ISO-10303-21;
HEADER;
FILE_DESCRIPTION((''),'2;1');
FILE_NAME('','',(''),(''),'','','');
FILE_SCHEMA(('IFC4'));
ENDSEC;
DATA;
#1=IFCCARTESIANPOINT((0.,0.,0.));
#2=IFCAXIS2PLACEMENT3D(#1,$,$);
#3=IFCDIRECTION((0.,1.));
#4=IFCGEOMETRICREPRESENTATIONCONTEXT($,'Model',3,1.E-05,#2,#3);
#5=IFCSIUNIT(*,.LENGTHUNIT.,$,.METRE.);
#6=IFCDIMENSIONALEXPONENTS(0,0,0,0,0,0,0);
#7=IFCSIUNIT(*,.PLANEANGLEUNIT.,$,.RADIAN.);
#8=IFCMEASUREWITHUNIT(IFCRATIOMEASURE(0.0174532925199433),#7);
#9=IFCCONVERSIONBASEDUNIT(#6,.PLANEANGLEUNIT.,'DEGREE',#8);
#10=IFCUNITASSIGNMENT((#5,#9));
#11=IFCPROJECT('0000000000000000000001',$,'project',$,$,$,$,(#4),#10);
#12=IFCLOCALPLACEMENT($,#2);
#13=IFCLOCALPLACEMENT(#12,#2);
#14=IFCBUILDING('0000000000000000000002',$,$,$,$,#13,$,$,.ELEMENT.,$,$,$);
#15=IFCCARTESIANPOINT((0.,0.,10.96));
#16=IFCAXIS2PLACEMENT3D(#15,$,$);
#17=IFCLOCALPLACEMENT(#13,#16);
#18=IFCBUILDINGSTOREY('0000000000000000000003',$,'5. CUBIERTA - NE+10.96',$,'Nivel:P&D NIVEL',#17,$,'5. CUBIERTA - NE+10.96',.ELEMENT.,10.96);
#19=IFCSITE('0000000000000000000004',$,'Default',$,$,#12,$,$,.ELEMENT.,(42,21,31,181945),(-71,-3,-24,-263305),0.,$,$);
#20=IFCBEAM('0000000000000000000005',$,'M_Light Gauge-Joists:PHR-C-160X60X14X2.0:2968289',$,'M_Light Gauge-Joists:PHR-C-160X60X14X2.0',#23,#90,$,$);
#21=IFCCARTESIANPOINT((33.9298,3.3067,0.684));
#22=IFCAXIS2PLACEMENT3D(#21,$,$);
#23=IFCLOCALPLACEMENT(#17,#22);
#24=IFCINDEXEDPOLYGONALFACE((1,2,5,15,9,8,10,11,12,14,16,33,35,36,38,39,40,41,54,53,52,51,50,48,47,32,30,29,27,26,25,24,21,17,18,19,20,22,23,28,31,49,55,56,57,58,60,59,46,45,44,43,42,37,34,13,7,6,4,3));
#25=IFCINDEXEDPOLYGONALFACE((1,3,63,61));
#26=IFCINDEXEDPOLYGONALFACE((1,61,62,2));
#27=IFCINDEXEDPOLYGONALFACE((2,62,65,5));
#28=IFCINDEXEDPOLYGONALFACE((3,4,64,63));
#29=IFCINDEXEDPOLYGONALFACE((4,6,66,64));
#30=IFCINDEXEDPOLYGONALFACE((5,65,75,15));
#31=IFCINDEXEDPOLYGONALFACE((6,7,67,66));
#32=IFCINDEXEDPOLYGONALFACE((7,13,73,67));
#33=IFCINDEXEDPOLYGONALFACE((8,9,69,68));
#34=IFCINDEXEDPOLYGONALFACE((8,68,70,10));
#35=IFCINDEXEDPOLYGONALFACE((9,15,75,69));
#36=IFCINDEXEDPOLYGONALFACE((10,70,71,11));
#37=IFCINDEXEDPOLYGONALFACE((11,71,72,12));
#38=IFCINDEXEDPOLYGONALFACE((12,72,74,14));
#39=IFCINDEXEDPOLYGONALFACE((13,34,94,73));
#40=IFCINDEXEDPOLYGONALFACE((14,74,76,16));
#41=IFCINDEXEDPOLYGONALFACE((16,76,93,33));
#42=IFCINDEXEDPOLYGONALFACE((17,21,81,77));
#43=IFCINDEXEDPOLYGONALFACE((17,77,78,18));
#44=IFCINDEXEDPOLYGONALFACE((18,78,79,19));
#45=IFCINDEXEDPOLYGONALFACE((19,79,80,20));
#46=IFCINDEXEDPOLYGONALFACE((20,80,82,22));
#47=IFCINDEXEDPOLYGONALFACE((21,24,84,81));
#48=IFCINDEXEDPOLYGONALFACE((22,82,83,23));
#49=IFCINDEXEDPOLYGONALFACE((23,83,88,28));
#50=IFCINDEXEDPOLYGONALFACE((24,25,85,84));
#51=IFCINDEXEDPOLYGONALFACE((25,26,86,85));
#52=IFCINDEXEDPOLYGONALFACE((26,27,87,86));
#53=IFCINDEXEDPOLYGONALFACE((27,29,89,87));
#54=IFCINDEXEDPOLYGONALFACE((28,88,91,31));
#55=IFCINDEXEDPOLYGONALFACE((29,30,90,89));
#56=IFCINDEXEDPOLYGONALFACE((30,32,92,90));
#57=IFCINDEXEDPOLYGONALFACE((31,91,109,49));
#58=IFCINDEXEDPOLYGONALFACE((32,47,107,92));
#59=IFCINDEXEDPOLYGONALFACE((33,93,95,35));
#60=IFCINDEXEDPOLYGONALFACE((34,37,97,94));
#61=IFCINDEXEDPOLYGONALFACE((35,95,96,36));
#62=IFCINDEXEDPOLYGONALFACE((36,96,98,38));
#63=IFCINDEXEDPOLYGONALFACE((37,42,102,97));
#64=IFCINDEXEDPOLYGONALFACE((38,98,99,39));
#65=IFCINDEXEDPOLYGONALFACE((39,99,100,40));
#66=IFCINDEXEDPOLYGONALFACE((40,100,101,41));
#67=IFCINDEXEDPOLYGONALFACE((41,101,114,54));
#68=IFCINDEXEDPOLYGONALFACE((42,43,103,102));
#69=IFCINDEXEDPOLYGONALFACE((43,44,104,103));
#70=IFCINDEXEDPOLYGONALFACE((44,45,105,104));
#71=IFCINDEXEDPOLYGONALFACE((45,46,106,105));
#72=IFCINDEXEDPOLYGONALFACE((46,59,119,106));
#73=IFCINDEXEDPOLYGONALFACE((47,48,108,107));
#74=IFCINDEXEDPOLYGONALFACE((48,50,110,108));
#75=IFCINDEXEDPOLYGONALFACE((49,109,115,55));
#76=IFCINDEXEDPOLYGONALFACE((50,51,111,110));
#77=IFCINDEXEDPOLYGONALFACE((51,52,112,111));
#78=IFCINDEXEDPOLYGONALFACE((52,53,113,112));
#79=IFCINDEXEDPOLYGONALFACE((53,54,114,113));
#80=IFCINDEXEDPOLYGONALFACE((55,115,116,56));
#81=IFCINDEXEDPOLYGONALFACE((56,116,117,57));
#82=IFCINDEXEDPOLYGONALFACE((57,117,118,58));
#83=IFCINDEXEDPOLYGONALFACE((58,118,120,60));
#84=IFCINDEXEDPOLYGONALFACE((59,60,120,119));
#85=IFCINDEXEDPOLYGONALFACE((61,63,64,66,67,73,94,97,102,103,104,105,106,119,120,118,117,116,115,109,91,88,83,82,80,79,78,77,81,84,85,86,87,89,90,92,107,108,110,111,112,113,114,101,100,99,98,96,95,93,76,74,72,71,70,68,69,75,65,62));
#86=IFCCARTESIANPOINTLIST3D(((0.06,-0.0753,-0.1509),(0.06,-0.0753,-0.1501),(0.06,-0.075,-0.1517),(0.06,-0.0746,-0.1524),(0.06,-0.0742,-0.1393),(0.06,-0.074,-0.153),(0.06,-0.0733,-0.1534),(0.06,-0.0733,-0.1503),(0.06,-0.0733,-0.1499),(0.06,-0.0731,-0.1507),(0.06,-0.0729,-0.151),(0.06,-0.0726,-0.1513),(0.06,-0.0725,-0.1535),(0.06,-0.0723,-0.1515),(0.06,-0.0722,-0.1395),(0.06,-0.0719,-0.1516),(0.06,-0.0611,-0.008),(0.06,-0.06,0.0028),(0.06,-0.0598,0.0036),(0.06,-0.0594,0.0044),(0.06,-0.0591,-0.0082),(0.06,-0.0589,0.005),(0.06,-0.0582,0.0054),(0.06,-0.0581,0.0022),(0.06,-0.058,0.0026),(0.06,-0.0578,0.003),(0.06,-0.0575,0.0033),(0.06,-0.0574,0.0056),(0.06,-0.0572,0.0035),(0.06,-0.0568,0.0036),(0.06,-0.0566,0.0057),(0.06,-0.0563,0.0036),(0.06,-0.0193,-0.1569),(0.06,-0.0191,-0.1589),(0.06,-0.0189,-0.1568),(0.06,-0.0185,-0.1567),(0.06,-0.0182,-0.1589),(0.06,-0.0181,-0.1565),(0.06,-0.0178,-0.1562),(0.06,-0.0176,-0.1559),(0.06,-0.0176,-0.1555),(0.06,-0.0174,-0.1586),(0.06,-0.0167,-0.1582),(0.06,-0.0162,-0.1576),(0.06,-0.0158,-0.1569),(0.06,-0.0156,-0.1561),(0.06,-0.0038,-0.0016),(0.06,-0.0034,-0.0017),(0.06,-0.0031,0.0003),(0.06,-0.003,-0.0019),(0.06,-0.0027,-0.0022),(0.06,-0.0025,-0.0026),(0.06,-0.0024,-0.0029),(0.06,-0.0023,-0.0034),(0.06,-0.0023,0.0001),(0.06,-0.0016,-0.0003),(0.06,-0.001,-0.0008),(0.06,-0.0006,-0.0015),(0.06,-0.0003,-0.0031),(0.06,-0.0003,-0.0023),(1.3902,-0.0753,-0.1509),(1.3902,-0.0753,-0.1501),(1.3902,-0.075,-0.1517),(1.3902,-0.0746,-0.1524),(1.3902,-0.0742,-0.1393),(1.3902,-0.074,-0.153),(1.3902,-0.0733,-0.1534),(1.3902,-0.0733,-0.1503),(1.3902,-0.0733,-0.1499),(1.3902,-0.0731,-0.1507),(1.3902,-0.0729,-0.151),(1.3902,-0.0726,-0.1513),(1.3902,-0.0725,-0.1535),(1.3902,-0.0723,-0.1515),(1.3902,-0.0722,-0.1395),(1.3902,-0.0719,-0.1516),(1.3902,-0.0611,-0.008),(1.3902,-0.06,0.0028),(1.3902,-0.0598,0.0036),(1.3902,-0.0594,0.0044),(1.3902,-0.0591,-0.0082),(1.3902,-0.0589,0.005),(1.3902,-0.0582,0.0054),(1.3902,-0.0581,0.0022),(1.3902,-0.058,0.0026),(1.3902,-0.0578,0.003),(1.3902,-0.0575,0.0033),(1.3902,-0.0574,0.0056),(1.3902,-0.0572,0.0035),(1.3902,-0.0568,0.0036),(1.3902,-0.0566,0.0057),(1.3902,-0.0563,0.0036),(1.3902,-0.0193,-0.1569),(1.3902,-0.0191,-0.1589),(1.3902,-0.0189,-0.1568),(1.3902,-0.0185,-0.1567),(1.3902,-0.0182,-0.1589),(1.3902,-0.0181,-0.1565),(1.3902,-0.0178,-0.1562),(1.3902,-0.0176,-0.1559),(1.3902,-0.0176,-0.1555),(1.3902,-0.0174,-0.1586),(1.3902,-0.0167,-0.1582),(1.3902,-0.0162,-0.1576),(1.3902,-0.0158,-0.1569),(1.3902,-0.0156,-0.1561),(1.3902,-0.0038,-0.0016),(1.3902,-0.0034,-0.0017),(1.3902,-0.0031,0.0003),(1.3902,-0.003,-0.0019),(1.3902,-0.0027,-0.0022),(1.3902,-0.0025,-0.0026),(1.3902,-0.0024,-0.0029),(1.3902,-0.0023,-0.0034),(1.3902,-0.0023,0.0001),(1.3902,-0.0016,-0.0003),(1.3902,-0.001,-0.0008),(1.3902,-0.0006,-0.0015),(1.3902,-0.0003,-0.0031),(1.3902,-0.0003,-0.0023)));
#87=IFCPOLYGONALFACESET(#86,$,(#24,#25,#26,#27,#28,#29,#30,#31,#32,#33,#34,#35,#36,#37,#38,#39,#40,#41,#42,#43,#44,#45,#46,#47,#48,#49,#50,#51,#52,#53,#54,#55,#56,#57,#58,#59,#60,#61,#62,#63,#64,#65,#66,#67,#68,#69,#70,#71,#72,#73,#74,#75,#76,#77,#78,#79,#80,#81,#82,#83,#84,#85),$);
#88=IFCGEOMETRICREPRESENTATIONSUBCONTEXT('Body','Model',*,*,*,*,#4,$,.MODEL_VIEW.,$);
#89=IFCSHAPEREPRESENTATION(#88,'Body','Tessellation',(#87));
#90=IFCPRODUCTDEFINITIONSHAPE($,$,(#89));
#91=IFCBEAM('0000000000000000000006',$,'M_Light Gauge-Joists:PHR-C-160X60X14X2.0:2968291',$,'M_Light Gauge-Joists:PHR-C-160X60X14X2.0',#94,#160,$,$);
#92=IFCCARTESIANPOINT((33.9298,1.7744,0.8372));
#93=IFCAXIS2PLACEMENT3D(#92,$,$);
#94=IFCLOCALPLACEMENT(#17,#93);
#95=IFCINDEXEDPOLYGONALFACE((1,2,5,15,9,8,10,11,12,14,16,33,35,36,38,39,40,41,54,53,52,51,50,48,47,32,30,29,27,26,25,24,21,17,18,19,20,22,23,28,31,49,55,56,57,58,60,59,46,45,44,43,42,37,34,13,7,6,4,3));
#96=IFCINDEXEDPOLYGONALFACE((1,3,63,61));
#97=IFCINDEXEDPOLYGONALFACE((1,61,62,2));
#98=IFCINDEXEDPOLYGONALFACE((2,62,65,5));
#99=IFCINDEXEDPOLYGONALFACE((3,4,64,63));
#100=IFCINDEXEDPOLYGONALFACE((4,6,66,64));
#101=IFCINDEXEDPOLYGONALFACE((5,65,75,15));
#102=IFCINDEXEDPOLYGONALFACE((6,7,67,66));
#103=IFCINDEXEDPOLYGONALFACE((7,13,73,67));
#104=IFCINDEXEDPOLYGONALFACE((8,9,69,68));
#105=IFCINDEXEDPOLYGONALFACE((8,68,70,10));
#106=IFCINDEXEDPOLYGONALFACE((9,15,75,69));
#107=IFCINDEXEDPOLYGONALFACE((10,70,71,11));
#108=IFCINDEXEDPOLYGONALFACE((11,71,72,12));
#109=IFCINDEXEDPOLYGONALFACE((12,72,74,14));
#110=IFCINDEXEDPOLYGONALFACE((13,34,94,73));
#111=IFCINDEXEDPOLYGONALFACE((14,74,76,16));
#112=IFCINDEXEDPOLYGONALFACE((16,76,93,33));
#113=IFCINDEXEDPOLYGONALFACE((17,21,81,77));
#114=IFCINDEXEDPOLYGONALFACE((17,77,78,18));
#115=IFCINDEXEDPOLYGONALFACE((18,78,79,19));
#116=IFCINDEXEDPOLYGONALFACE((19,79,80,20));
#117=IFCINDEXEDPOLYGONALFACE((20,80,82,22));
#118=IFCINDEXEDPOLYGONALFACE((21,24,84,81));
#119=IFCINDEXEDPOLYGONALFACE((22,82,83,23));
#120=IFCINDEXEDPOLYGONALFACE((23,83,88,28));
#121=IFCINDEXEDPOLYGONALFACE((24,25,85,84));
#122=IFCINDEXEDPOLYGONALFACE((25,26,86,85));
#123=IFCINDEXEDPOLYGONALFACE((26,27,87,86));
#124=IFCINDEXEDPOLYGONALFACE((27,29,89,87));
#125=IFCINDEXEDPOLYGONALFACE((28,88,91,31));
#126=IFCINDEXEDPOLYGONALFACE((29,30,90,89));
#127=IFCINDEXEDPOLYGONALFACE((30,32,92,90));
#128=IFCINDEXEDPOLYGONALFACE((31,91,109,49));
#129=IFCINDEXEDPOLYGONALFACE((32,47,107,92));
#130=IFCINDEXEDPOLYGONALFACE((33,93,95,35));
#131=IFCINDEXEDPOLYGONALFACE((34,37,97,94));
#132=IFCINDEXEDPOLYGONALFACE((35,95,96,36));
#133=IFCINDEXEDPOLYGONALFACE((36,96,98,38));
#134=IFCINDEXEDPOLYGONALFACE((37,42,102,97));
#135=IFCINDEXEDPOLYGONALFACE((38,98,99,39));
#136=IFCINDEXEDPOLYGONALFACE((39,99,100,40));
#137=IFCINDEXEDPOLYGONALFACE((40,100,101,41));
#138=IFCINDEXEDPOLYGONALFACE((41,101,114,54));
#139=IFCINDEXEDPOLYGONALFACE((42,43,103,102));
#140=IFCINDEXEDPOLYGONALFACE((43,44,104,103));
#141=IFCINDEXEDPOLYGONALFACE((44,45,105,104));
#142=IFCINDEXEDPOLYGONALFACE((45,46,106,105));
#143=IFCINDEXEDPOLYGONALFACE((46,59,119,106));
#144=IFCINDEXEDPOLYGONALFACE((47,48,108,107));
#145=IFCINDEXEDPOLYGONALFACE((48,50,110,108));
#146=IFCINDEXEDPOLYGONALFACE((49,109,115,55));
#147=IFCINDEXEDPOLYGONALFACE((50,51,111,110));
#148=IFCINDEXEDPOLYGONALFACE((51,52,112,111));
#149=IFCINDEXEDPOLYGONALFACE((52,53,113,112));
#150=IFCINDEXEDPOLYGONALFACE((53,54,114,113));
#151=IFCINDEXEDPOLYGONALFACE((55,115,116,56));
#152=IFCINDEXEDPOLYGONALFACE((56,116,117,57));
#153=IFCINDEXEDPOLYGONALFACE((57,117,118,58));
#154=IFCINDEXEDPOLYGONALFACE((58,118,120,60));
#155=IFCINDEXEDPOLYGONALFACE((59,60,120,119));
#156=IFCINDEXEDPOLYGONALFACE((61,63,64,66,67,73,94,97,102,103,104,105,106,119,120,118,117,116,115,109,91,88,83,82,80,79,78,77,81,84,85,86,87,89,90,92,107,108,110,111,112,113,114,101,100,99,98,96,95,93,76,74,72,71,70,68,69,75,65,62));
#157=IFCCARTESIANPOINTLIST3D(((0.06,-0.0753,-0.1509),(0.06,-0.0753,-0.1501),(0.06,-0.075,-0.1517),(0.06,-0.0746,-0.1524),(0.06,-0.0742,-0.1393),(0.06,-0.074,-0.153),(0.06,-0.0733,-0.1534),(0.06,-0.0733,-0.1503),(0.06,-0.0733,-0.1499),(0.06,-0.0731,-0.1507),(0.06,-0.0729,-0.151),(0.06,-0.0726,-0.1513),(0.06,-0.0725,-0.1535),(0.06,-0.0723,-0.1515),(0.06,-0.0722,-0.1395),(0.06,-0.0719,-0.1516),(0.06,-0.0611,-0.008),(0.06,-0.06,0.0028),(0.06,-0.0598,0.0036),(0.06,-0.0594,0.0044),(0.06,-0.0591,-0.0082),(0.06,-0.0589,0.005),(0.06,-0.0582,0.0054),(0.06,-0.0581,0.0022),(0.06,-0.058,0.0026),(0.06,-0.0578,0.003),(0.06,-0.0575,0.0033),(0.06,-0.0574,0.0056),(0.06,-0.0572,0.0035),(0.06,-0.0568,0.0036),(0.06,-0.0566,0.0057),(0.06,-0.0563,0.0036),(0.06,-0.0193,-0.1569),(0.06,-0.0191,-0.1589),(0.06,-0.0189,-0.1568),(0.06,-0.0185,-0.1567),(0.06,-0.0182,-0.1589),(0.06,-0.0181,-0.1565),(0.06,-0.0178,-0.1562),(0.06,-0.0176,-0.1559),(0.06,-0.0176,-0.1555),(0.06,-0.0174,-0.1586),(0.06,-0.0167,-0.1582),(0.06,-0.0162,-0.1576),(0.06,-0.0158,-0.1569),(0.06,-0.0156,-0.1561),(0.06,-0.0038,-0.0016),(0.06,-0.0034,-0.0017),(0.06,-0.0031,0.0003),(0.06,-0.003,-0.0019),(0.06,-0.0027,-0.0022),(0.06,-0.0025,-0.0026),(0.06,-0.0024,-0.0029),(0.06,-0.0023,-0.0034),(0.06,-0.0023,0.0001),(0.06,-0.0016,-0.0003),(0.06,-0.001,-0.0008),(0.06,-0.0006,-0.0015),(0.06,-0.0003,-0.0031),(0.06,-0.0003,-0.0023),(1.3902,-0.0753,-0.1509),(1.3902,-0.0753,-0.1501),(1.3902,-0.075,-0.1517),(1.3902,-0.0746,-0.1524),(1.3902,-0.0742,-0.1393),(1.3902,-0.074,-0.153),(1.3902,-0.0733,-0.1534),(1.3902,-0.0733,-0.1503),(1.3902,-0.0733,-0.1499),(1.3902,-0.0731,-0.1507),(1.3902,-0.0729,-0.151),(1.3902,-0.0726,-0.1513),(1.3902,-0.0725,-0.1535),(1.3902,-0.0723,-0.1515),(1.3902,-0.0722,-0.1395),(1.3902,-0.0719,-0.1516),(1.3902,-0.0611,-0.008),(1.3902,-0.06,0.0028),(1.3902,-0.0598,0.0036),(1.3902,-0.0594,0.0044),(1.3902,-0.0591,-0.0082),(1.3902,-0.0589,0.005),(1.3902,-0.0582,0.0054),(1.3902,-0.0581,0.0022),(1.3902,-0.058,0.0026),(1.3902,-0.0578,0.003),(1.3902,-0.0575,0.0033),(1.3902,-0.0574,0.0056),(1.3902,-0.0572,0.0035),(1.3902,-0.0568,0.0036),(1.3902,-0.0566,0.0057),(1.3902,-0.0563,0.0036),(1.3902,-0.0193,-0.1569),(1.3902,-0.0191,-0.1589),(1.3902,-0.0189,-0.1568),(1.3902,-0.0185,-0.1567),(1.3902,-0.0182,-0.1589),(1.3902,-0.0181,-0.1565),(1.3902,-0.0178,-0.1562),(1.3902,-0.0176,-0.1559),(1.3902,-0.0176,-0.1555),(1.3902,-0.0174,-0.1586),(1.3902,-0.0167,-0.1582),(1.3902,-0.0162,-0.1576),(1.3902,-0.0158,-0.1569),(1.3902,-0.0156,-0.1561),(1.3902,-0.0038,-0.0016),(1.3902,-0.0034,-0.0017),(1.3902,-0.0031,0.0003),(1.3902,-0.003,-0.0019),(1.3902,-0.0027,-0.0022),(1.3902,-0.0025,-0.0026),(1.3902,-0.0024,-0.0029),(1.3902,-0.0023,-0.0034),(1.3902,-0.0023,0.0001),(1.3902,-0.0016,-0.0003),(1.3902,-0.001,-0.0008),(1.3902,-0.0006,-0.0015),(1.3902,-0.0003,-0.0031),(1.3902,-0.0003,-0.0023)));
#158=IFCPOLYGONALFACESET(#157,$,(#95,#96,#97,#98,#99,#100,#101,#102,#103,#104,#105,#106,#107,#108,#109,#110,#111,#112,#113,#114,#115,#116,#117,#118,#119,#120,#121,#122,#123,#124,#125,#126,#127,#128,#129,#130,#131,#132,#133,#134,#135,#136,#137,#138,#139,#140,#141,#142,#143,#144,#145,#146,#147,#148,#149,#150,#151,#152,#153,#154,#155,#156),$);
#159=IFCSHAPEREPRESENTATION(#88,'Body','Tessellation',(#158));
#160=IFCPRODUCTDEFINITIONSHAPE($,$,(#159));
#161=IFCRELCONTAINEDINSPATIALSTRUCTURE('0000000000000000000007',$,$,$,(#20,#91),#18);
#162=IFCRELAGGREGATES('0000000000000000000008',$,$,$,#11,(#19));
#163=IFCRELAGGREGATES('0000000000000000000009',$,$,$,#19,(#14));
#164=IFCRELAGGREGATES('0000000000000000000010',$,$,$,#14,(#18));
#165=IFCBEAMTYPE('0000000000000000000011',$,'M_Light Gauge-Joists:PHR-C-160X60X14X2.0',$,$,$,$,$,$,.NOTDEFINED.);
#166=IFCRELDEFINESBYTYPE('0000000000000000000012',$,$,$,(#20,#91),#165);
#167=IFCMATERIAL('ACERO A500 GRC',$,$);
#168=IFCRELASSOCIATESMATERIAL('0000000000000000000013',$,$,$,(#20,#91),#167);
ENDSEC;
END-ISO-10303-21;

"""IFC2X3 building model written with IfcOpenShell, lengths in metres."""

from ifc_helpers import new_model, entity, si_unit, converted_unit, direction, frame, frame_2d, origin, place, context, subcontext, project, spatial, polyline, circle_curve, parameter, trimmed, segment, composite_curve, outline, extrude, material, type_object, element, save


model = new_model("IFC2X3")

# Units and contexts
model_context = context("Model", 3, precision=1e-05, world=origin(), true_north=direction((0.0, 1.0)))
body_context = subcontext(model_context, "Body", "Model", "MODEL_VIEW")
ifc_project = project(units=[si_unit("LENGTHUNIT", "METRE"), converted_unit("PLANEANGLEUNIT", "DEGREE", entity("IfcRatioMeasure", 0.0174532925199433), si_unit("PLANEANGLEUNIT", "RADIAN"), dimensions=[0, 0, 0, 0, 0, 0, 0])], contexts=[model_context])

# Site, building, storey
site_placement = place(None, origin())
site = spatial("IfcSite", under=ifc_project, at=site_placement, Name="Default", CompositionType="ELEMENT", RefLatitude=(42, 21, 31, 181945), RefLongitude=(-71, -3, -24, -263305), RefElevation=0.0)
building_placement = place(site_placement, origin())
building = spatial("IfcBuilding", under=site, at=building_placement, CompositionType="ELEMENT")
storey_placement = place(building_placement, frame((0.0, 0.0, 10.96)))
storey = spatial("IfcBuildingStorey", under=building, at=storey_placement, Name="5. CUBIERTA - NE+10.96", ObjectType="Nivel:P&D NIVEL", LongName="5. CUBIERTA - NE+10.96", CompositionType="ELEMENT", Elevation=10.96)

# Beams
ifc_material_1 = material(Name="ACERO A500 GRC")
beam_type_1 = type_object("IfcBeamType", Name="M_Light Gauge-Joists:PHR-C-160X60X14X2.0", PredefinedType="NOTDEFINED")
beam_1_placement = place(storey_placement, frame((33.9298, 3.3067, 0.684)))
element("IfcBeam", 1, at=beam_1_placement, inside=storey, type_object=beam_type_1, material=ifc_material_1, Name="M_Light Gauge-Joists:PHR-C-160X60X14X2.0:2968289", ObjectType="M_Light Gauge-Joists:PHR-C-160X60X14X2.0", context=body_context, shape_type="SweptSolid", body=[
    extrude(outline(composite_curve([segment(polyline([(-0.0768, -0.0358), (0.0768, -0.0358)]), True, "CONTINUOUS"), segment(trimmed(circle_curve(frame_2d((0.0768, -0.0326), x_axis=(0.0, -1.0)), 0.0032), [parameter(0.0)], [parameter(90.0)], True, "PARAMETER"), True, "CONTINUOUS"), segment(polyline([(0.08, -0.0326), (0.08, 0.021)]), True, "CONTINUOUS"), segment(trimmed(circle_curve(frame_2d((0.0768, 0.021), x_axis=(1.0, 0.0)), 0.0032), [parameter(0.0)], [parameter(90.0)], True, "PARAMETER"), True, "CONTINUOUS"), segment(polyline([(0.0768, 0.0242), (0.066, 0.0242)]), True, "CONTINUOUS"), segment(polyline([(0.066, 0.0242), (0.066, 0.0222)]), True, "CONTINUOUS"), segment(polyline([(0.066, 0.0222), (0.0764, 0.0222)]), True, "CONTINUOUS"), segment(trimmed(circle_curve(frame_2d((0.0764, 0.0206), x_axis=(0.0, 1.0)), 0.0016), [parameter(270.0)], [parameter(0.0)], True, "PARAMETER"), False, "CONTINUOUS"), segment(polyline([(0.078, 0.0206), (0.078, -0.0322)]), True, "CONTINUOUS"), segment(trimmed(circle_curve(frame_2d((0.0764, -0.0322), x_axis=(1.0, 0.0)), 0.0016), [parameter(270.0)], [parameter(0.0)], True, "PARAMETER"), False, "CONTINUOUS"), segment(polyline([(0.0764, -0.0338), (-0.0764, -0.0338)]), True, "CONTINUOUS"), segment(trimmed(circle_curve(frame_2d((-0.0764, -0.0322), x_axis=(0.0, -1.0)), 0.0016), [parameter(270.0)], [parameter(0.0)], True, "PARAMETER"), False, "CONTINUOUS"), segment(polyline([(-0.078, -0.0322), (-0.078, 0.0206)]), True, "CONTINUOUS"), segment(trimmed(circle_curve(frame_2d((-0.0764, 0.0206), x_axis=(-1.0, 0.0)), 0.0016), [parameter(270.0)], [parameter(0.0)], True, "PARAMETER"), False, "CONTINUOUS"), segment(polyline([(-0.0764, 0.0222), (-0.066, 0.0222)]), True, "CONTINUOUS"), segment(polyline([(-0.066, 0.0222), (-0.066, 0.0242)]), True, "CONTINUOUS"), segment(polyline([(-0.066, 0.0242), (-0.0768, 0.0242)]), True, "CONTINUOUS"), segment(trimmed(circle_curve(frame_2d((-0.0768, 0.021), x_axis=(0.0, 1.0)), 0.0032), [parameter(0.0)], [parameter(90.0)], True, "PARAMETER"), True, "CONTINUOUS"), segment(polyline([(-0.08, 0.021), (-0.08, -0.0326)]), True, "CONTINUOUS"), segment(trimmed(circle_curve(frame_2d((-0.0768, -0.0326), x_axis=(-1.0, 0.0)), 0.0032), [parameter(0.0)], [parameter(90.0)], True, "PARAMETER"), True, "CONTINUOUS")], self_intersect=False)), frame((0.06, -0.0436, -0.076), z_axis=(1.0, 0.0, 0.0), x_axis=(0.0, 0.099504, 0.995037)), (0.0, 0.0, 1.0), 1.3302),
])
beam_2_placement = place(storey_placement, frame((33.9298, 1.7744, 0.8372)))
element("IfcBeam", 2, at=beam_2_placement, inside=storey, type_object=beam_type_1, material=ifc_material_1, Name="M_Light Gauge-Joists:PHR-C-160X60X14X2.0:2968291", ObjectType="M_Light Gauge-Joists:PHR-C-160X60X14X2.0", context=body_context, shape_type="SweptSolid", body=[
    extrude(outline(composite_curve([segment(polyline([(-0.0768, -0.0358), (0.0768, -0.0358)]), True, "CONTINUOUS"), segment(trimmed(circle_curve(frame_2d((0.0768, -0.0326), x_axis=(0.0, -1.0)), 0.0032), [parameter(0.0)], [parameter(90.0)], True, "PARAMETER"), True, "CONTINUOUS"), segment(polyline([(0.08, -0.0326), (0.08, 0.021)]), True, "CONTINUOUS"), segment(trimmed(circle_curve(frame_2d((0.0768, 0.021), x_axis=(1.0, 0.0)), 0.0032), [parameter(0.0)], [parameter(90.0)], True, "PARAMETER"), True, "CONTINUOUS"), segment(polyline([(0.0768, 0.0242), (0.066, 0.0242)]), True, "CONTINUOUS"), segment(polyline([(0.066, 0.0242), (0.066, 0.0222)]), True, "CONTINUOUS"), segment(polyline([(0.066, 0.0222), (0.0764, 0.0222)]), True, "CONTINUOUS"), segment(trimmed(circle_curve(frame_2d((0.0764, 0.0206), x_axis=(0.0, 1.0)), 0.0016), [parameter(270.0)], [parameter(0.0)], True, "PARAMETER"), False, "CONTINUOUS"), segment(polyline([(0.078, 0.0206), (0.078, -0.0322)]), True, "CONTINUOUS"), segment(trimmed(circle_curve(frame_2d((0.0764, -0.0322), x_axis=(1.0, 0.0)), 0.0016), [parameter(270.0)], [parameter(0.0)], True, "PARAMETER"), False, "CONTINUOUS"), segment(polyline([(0.0764, -0.0338), (-0.0764, -0.0338)]), True, "CONTINUOUS"), segment(trimmed(circle_curve(frame_2d((-0.0764, -0.0322), x_axis=(0.0, -1.0)), 0.0016), [parameter(270.0)], [parameter(0.0)], True, "PARAMETER"), False, "CONTINUOUS"), segment(polyline([(-0.078, -0.0322), (-0.078, 0.0206)]), True, "CONTINUOUS"), segment(trimmed(circle_curve(frame_2d((-0.0764, 0.0206), x_axis=(-1.0, 0.0)), 0.0016), [parameter(270.0)], [parameter(0.0)], True, "PARAMETER"), False, "CONTINUOUS"), segment(polyline([(-0.0764, 0.0222), (-0.066, 0.0222)]), True, "CONTINUOUS"), segment(polyline([(-0.066, 0.0222), (-0.066, 0.0242)]), True, "CONTINUOUS"), segment(polyline([(-0.066, 0.0242), (-0.0768, 0.0242)]), True, "CONTINUOUS"), segment(trimmed(circle_curve(frame_2d((-0.0768, 0.021), x_axis=(0.0, 1.0)), 0.0032), [parameter(0.0)], [parameter(90.0)], True, "PARAMETER"), True, "CONTINUOUS"), segment(polyline([(-0.08, 0.021), (-0.08, -0.0326)]), True, "CONTINUOUS"), segment(trimmed(circle_curve(frame_2d((-0.0768, -0.0326), x_axis=(-1.0, 0.0)), 0.0032), [parameter(0.0)], [parameter(90.0)], True, "PARAMETER"), True, "CONTINUOUS")], self_intersect=False)), frame((0.06, -0.0436, -0.076), z_axis=(1.0, 0.0, 0.0), x_axis=(0.0, 0.099504, 0.995037)), (0.0, 0.0, 1.0), 1.3302),
])

save(model, "model.ifc")
